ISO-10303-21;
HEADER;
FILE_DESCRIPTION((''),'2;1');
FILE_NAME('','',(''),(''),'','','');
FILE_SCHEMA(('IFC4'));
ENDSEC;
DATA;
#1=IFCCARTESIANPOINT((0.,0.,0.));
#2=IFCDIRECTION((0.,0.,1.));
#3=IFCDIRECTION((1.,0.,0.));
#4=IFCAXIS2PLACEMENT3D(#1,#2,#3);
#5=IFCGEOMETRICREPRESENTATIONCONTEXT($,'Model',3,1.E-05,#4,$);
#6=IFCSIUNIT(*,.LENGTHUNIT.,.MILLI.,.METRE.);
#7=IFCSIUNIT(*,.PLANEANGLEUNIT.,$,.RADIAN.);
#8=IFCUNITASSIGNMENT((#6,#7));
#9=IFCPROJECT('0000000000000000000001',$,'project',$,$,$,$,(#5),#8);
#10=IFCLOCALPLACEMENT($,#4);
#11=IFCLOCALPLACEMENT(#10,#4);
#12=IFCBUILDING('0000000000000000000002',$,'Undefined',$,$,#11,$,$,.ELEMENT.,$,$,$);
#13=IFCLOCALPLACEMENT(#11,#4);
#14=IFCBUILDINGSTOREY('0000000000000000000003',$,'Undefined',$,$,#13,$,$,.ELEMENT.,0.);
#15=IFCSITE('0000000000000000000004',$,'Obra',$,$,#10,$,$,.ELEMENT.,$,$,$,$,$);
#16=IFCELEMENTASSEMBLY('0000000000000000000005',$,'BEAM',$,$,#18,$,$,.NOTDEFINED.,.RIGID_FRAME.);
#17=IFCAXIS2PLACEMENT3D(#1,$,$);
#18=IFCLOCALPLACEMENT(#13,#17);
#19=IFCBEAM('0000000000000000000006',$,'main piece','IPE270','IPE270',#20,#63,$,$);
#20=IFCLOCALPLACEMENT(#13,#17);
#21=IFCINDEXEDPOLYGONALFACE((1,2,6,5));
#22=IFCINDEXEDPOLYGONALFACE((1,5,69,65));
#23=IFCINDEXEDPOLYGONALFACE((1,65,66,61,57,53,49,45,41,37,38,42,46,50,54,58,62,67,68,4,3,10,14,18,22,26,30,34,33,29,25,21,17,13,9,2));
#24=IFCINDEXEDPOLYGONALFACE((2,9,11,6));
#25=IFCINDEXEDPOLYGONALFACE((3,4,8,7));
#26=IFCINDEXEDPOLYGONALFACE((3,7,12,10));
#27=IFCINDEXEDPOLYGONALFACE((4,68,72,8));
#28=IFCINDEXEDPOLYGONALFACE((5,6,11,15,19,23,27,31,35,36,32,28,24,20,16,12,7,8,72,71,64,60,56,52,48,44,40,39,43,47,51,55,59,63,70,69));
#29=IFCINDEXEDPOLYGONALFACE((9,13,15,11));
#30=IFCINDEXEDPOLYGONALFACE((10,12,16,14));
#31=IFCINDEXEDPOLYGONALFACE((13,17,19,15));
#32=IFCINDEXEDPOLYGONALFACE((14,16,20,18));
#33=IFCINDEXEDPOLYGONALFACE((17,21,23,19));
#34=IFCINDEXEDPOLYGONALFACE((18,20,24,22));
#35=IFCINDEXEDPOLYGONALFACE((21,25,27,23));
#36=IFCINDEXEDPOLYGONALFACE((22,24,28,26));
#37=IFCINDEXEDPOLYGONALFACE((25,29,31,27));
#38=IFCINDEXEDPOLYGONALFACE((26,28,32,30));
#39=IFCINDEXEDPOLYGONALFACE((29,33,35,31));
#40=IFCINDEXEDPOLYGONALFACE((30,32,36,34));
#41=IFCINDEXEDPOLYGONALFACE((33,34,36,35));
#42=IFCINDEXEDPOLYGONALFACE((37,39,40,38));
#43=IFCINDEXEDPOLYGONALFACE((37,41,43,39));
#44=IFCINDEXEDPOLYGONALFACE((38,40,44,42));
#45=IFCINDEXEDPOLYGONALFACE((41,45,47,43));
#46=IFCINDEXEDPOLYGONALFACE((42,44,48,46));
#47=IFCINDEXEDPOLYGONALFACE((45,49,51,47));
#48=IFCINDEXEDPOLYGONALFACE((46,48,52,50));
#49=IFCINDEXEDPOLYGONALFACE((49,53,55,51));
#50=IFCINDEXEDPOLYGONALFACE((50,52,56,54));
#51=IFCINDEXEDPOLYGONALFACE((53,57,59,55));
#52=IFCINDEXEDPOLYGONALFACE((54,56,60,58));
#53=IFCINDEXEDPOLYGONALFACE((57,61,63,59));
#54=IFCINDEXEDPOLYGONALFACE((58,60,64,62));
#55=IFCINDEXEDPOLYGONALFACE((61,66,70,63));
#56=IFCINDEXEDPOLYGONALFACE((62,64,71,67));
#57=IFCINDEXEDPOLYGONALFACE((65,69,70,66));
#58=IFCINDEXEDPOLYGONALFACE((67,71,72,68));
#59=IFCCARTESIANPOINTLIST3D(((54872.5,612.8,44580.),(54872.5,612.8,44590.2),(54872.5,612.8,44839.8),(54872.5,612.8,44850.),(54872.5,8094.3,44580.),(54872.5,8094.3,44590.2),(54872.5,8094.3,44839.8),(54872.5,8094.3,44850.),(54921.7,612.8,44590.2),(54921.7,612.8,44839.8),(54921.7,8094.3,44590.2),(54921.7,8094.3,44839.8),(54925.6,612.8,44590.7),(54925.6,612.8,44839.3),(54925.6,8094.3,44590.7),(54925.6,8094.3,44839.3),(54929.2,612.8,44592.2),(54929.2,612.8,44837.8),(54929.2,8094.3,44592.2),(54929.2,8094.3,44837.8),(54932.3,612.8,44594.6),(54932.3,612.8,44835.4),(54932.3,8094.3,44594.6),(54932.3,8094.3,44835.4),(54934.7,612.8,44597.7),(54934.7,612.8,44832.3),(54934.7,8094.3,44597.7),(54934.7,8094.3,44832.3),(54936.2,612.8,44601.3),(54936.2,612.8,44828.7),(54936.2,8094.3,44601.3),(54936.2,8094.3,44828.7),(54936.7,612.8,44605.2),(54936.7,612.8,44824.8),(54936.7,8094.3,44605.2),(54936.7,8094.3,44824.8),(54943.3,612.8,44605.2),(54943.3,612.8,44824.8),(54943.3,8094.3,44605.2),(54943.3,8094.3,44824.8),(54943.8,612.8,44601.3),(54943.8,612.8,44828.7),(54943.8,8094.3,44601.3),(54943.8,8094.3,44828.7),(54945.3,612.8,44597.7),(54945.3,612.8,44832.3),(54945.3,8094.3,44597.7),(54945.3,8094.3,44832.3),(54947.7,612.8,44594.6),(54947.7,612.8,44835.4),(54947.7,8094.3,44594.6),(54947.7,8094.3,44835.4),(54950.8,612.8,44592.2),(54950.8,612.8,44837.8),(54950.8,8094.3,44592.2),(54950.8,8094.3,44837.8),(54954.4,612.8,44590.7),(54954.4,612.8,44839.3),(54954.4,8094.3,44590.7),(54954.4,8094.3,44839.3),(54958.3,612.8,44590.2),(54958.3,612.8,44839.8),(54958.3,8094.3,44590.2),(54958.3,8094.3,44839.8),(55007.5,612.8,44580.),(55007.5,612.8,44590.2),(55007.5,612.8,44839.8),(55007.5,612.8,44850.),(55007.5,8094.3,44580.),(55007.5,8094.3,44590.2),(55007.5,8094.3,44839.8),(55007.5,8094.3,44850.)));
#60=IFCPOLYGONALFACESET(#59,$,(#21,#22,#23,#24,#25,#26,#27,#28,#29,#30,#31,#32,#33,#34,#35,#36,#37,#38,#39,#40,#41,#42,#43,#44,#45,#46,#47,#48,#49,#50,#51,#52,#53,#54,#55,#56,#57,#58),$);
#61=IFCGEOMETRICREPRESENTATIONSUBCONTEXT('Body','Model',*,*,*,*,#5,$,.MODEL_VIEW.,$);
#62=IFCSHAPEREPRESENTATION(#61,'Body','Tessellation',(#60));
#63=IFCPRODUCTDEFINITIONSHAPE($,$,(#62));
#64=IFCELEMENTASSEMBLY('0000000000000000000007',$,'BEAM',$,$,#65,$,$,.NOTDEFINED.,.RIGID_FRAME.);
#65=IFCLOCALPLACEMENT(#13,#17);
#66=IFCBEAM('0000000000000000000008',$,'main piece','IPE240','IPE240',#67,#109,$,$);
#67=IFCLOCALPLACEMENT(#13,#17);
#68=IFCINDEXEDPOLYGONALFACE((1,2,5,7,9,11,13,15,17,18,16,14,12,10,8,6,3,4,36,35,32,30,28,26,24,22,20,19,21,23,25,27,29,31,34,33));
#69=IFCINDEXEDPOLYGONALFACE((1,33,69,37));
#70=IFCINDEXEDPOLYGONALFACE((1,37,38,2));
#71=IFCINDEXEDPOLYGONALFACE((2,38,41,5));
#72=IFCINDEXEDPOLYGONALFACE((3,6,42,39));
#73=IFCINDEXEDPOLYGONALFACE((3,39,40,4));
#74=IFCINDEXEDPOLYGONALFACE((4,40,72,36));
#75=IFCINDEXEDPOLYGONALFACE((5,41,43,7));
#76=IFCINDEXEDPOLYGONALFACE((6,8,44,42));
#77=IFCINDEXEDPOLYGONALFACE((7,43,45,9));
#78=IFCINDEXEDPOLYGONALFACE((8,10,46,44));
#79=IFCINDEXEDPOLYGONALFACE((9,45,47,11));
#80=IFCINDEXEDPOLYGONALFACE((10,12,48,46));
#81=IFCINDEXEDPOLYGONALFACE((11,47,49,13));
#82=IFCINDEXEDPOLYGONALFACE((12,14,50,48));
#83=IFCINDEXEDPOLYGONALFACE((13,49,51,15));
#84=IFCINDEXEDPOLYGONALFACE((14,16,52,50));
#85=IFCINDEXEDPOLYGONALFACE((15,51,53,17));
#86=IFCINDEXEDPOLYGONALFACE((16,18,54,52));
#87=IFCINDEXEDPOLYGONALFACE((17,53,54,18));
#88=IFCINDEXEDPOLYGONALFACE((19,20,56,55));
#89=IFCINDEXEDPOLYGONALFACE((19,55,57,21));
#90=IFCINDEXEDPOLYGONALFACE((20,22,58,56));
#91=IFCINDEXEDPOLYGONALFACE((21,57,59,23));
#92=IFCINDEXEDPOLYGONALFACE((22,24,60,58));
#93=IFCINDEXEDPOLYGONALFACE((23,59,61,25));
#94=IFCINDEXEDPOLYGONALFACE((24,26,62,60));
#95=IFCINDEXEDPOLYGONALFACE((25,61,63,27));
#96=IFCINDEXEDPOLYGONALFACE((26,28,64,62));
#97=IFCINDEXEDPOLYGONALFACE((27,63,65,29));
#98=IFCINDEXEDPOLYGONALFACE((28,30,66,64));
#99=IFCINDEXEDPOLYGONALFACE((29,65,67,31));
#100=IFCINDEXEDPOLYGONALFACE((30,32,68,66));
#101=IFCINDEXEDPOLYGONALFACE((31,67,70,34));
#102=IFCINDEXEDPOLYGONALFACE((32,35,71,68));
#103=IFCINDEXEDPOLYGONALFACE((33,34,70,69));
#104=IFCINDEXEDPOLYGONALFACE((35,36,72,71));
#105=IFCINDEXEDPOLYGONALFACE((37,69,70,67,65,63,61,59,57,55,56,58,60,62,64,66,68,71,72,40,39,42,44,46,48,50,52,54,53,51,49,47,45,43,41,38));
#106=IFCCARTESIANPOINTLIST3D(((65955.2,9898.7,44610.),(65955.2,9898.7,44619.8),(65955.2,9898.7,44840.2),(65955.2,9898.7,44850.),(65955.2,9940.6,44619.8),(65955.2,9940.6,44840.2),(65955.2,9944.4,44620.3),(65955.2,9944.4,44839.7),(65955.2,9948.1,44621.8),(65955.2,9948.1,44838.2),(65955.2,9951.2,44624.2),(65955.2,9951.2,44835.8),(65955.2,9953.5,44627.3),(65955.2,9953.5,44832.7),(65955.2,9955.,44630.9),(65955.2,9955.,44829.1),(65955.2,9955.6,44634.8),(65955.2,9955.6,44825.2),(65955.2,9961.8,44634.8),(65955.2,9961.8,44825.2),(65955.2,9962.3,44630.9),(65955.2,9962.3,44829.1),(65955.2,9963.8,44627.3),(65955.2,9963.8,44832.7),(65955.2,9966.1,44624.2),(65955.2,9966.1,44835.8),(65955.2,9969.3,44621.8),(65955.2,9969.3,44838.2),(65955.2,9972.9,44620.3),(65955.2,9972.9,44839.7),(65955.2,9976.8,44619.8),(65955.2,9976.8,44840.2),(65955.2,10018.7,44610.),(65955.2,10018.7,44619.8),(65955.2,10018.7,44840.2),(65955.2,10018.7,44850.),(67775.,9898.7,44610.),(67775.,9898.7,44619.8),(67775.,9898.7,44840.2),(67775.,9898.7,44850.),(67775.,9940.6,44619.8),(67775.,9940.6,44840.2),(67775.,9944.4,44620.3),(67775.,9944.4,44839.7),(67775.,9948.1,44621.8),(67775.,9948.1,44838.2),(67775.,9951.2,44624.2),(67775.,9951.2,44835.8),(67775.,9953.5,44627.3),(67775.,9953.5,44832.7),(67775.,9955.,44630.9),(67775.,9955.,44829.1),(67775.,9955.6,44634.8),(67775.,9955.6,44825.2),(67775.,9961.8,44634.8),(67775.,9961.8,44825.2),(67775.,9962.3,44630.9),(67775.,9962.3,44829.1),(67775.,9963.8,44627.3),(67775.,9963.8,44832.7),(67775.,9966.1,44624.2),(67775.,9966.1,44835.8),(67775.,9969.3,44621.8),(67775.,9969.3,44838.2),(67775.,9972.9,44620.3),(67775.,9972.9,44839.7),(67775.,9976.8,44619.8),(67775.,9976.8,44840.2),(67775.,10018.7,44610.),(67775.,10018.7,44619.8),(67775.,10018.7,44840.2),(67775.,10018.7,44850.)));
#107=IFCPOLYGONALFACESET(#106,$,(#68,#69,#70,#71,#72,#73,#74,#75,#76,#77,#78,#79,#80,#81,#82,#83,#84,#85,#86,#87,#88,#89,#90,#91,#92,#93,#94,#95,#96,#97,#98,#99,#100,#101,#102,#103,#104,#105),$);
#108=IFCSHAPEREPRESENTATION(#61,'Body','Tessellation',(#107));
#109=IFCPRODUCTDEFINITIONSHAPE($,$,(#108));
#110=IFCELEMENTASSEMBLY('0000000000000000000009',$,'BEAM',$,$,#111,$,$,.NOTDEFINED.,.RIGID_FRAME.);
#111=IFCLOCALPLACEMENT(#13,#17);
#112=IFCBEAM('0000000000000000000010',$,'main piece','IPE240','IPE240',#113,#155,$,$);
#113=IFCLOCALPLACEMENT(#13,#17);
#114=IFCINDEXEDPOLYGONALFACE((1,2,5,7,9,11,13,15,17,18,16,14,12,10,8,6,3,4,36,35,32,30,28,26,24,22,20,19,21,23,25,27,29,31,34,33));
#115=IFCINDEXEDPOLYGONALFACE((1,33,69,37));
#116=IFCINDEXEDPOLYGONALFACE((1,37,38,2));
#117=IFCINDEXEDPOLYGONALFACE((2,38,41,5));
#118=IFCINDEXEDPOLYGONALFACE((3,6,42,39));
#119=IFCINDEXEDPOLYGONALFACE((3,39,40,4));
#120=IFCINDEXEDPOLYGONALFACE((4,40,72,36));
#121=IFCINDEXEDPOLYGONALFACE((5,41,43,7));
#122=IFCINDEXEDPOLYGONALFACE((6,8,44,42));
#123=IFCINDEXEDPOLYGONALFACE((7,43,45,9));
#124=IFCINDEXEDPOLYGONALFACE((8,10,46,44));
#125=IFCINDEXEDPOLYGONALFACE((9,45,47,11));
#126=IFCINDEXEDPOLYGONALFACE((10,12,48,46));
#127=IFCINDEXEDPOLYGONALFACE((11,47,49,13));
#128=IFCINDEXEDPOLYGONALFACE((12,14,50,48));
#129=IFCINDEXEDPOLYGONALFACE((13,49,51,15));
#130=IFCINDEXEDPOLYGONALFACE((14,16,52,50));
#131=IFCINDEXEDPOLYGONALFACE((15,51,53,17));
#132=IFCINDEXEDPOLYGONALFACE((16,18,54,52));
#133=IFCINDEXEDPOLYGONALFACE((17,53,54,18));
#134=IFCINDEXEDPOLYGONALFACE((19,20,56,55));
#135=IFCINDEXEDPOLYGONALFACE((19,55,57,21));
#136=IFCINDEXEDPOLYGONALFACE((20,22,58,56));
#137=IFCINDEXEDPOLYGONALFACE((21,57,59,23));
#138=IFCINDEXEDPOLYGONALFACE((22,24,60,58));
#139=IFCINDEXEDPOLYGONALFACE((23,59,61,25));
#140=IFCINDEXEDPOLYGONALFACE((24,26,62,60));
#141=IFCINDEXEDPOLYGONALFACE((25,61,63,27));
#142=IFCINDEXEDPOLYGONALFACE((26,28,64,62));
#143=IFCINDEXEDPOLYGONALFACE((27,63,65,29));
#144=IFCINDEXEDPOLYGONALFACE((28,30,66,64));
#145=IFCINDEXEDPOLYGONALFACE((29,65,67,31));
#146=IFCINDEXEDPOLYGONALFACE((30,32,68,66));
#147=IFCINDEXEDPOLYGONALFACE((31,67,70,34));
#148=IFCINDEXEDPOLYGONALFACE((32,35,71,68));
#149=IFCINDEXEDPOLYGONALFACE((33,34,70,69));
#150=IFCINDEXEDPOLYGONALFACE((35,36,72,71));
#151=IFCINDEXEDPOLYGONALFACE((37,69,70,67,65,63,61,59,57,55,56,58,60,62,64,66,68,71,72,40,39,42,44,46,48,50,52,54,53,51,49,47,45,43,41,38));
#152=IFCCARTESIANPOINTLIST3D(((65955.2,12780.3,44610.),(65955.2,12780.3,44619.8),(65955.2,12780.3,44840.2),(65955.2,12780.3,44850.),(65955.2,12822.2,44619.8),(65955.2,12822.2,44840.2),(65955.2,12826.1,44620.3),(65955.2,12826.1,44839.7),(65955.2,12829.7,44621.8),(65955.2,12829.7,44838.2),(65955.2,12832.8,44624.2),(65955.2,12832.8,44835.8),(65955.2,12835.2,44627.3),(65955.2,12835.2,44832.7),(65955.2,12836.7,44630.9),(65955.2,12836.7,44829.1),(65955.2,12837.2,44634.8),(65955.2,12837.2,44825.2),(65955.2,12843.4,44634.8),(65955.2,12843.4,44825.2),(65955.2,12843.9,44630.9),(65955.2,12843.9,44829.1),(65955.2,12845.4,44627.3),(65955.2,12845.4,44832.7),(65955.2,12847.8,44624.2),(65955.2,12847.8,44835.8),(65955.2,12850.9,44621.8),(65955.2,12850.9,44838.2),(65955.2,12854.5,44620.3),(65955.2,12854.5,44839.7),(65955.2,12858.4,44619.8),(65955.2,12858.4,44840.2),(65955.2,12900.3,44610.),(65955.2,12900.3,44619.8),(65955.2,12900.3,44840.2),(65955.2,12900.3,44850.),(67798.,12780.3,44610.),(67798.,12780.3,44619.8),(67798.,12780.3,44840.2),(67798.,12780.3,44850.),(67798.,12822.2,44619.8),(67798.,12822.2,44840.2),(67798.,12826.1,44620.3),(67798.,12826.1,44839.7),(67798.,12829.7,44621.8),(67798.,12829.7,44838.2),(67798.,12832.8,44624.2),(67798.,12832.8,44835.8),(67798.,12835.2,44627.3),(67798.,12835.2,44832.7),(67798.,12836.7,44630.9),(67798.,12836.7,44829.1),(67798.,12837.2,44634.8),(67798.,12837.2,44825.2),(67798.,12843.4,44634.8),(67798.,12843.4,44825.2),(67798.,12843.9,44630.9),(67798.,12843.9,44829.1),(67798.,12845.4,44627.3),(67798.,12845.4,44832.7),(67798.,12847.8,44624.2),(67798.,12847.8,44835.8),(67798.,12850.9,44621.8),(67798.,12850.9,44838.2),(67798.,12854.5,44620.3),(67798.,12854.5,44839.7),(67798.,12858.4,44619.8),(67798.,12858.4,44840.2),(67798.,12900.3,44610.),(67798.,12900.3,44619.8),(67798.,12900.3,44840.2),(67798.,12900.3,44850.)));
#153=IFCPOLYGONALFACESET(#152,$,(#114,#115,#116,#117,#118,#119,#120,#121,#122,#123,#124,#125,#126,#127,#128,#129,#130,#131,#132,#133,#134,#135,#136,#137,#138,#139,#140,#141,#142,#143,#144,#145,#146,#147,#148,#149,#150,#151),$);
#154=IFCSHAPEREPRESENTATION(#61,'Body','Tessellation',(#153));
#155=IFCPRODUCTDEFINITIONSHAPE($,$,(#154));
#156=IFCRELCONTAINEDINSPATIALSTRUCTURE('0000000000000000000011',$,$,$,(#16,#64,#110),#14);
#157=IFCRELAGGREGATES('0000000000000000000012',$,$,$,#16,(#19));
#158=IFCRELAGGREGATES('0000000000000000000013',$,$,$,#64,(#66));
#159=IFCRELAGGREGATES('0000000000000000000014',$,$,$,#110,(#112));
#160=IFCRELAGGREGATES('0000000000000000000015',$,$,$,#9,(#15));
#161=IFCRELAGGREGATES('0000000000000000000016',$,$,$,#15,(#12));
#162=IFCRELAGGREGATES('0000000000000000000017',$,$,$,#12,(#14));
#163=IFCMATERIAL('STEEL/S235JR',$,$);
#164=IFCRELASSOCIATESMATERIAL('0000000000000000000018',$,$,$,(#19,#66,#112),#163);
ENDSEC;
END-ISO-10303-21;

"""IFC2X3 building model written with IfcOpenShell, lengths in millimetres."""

from ifc_helpers import new_model, si_unit, frame, origin_with_axes, origin_2d_with_axis, place, context, subcontext, project, spatial, i_section, extrude, material, element, aggregate, save


model = new_model("IFC2X3")

# Units and contexts
model_context = context("Model", 3, precision=1e-05, world=origin_with_axes())
body_context = subcontext(model_context, "Body", "Model", "MODEL_VIEW")
ifc_project = project(units=[si_unit("LENGTHUNIT", "METRE", prefix="MILLI"), si_unit("PLANEANGLEUNIT", "RADIAN")], contexts=[model_context])

# Site, building, storey
site_placement = place(None, origin_with_axes())
site = spatial("IfcSite", under=ifc_project, at=site_placement, Name="Obra", CompositionType="ELEMENT")
building_placement = place(site_placement, origin_with_axes())
building = spatial("IfcBuilding", under=site, at=building_placement, Name="Undefined", CompositionType="ELEMENT")
storey_placement = place(building_placement, origin_with_axes())
storey = spatial("IfcBuildingStorey", under=building, at=storey_placement, Name="Undefined", CompositionType="ELEMENT", Elevation=0.0)

# Shared definitions
ifc_material_1 = material(Name="STEEL/S235JR")

# Element assemblies, beams
assembly_1_placement = place(storey_placement, origin_with_axes())
assembly_1 = element("IfcElementAssembly", 1, at=assembly_1_placement, inside=storey, Name="BEAM", AssemblyPlace="NOTDEFINED", PredefinedType="RIGID_FRAME")
beam_1_placement = place(assembly_1_placement, frame((54940.0, 8094.3, 44715.0), z_axis=(0.0, 0.0, 1.0), x_axis=(0.0, -1.0, 0.0)))
beam_1 = element("IfcBeam", 2, at=beam_1_placement, material=ifc_material_1, Name="main piece", Description="IPE270", ObjectType="IPE270", context=body_context, shape_type="SweptSolid", body=[
    extrude(i_section(OverallWidth=135.0, OverallDepth=270.0, WebThickness=6.6, FlangeThickness=10.2, FilletRadius=15.0, at=origin_2d_with_axis()), frame((7481.5, 0.0, 0.0), z_axis=(-1.0, 0.0, 0.0), x_axis=(0.0, -1.0, 0.0)), (0.0, 0.0, 1.0), 7481.5),
])
aggregate(assembly_1, [beam_1])
assembly_2_placement = place(storey_placement, origin_with_axes())
assembly_2 = element("IfcElementAssembly", 3, at=assembly_2_placement, inside=storey, Name="BEAM", AssemblyPlace="NOTDEFINED", PredefinedType="RIGID_FRAME")
beam_2_placement = place(assembly_2_placement, frame((65955.2, 9958.7, 44730.0), z_axis=(0.0, 0.0, 1.0), x_axis=(1.0, 0.0, 0.0)))
beam_2 = element("IfcBeam", 4, at=beam_2_placement, material=ifc_material_1, Name="main piece", Description="IPE240", ObjectType="IPE240", context=body_context, shape_type="SweptSolid", body=[
    extrude(i_section(OverallWidth=120.0, OverallDepth=240.0, WebThickness=6.2, FlangeThickness=9.8, FilletRadius=15.0, at=origin_2d_with_axis()), frame((1819.8, 0.0, 0.0), z_axis=(-1.0, 0.0, 0.0), x_axis=(0.0, -1.0, 0.0)), (0.0, 0.0, 1.0), 1819.8),
])
aggregate(assembly_2, [beam_2])
assembly_3_placement = place(storey_placement, origin_with_axes())
assembly_3 = element("IfcElementAssembly", 5, at=assembly_3_placement, inside=storey, Name="BEAM", AssemblyPlace="NOTDEFINED", PredefinedType="RIGID_FRAME")
beam_3_placement = place(assembly_3_placement, frame((65955.2, 12840.3, 44730.0), z_axis=(0.0, 0.0, 1.0), x_axis=(1.0, 0.0, 0.0)))
beam_3 = element("IfcBeam", 6, at=beam_3_placement, material=ifc_material_1, Name="main piece", Description="IPE240", ObjectType="IPE240", context=body_context, shape_type="SweptSolid", body=[
    extrude(i_section(OverallWidth=120.0, OverallDepth=240.0, WebThickness=6.2, FlangeThickness=9.8, FilletRadius=15.0, at=origin_2d_with_axis()), frame((1842.8, 0.0, 0.0), z_axis=(-1.0, 0.0, 0.0), x_axis=(0.0, -1.0, 0.0)), (0.0, 0.0, 1.0), 1842.8),
])
aggregate(assembly_3, [beam_3])

save(model, "model.ifc")
